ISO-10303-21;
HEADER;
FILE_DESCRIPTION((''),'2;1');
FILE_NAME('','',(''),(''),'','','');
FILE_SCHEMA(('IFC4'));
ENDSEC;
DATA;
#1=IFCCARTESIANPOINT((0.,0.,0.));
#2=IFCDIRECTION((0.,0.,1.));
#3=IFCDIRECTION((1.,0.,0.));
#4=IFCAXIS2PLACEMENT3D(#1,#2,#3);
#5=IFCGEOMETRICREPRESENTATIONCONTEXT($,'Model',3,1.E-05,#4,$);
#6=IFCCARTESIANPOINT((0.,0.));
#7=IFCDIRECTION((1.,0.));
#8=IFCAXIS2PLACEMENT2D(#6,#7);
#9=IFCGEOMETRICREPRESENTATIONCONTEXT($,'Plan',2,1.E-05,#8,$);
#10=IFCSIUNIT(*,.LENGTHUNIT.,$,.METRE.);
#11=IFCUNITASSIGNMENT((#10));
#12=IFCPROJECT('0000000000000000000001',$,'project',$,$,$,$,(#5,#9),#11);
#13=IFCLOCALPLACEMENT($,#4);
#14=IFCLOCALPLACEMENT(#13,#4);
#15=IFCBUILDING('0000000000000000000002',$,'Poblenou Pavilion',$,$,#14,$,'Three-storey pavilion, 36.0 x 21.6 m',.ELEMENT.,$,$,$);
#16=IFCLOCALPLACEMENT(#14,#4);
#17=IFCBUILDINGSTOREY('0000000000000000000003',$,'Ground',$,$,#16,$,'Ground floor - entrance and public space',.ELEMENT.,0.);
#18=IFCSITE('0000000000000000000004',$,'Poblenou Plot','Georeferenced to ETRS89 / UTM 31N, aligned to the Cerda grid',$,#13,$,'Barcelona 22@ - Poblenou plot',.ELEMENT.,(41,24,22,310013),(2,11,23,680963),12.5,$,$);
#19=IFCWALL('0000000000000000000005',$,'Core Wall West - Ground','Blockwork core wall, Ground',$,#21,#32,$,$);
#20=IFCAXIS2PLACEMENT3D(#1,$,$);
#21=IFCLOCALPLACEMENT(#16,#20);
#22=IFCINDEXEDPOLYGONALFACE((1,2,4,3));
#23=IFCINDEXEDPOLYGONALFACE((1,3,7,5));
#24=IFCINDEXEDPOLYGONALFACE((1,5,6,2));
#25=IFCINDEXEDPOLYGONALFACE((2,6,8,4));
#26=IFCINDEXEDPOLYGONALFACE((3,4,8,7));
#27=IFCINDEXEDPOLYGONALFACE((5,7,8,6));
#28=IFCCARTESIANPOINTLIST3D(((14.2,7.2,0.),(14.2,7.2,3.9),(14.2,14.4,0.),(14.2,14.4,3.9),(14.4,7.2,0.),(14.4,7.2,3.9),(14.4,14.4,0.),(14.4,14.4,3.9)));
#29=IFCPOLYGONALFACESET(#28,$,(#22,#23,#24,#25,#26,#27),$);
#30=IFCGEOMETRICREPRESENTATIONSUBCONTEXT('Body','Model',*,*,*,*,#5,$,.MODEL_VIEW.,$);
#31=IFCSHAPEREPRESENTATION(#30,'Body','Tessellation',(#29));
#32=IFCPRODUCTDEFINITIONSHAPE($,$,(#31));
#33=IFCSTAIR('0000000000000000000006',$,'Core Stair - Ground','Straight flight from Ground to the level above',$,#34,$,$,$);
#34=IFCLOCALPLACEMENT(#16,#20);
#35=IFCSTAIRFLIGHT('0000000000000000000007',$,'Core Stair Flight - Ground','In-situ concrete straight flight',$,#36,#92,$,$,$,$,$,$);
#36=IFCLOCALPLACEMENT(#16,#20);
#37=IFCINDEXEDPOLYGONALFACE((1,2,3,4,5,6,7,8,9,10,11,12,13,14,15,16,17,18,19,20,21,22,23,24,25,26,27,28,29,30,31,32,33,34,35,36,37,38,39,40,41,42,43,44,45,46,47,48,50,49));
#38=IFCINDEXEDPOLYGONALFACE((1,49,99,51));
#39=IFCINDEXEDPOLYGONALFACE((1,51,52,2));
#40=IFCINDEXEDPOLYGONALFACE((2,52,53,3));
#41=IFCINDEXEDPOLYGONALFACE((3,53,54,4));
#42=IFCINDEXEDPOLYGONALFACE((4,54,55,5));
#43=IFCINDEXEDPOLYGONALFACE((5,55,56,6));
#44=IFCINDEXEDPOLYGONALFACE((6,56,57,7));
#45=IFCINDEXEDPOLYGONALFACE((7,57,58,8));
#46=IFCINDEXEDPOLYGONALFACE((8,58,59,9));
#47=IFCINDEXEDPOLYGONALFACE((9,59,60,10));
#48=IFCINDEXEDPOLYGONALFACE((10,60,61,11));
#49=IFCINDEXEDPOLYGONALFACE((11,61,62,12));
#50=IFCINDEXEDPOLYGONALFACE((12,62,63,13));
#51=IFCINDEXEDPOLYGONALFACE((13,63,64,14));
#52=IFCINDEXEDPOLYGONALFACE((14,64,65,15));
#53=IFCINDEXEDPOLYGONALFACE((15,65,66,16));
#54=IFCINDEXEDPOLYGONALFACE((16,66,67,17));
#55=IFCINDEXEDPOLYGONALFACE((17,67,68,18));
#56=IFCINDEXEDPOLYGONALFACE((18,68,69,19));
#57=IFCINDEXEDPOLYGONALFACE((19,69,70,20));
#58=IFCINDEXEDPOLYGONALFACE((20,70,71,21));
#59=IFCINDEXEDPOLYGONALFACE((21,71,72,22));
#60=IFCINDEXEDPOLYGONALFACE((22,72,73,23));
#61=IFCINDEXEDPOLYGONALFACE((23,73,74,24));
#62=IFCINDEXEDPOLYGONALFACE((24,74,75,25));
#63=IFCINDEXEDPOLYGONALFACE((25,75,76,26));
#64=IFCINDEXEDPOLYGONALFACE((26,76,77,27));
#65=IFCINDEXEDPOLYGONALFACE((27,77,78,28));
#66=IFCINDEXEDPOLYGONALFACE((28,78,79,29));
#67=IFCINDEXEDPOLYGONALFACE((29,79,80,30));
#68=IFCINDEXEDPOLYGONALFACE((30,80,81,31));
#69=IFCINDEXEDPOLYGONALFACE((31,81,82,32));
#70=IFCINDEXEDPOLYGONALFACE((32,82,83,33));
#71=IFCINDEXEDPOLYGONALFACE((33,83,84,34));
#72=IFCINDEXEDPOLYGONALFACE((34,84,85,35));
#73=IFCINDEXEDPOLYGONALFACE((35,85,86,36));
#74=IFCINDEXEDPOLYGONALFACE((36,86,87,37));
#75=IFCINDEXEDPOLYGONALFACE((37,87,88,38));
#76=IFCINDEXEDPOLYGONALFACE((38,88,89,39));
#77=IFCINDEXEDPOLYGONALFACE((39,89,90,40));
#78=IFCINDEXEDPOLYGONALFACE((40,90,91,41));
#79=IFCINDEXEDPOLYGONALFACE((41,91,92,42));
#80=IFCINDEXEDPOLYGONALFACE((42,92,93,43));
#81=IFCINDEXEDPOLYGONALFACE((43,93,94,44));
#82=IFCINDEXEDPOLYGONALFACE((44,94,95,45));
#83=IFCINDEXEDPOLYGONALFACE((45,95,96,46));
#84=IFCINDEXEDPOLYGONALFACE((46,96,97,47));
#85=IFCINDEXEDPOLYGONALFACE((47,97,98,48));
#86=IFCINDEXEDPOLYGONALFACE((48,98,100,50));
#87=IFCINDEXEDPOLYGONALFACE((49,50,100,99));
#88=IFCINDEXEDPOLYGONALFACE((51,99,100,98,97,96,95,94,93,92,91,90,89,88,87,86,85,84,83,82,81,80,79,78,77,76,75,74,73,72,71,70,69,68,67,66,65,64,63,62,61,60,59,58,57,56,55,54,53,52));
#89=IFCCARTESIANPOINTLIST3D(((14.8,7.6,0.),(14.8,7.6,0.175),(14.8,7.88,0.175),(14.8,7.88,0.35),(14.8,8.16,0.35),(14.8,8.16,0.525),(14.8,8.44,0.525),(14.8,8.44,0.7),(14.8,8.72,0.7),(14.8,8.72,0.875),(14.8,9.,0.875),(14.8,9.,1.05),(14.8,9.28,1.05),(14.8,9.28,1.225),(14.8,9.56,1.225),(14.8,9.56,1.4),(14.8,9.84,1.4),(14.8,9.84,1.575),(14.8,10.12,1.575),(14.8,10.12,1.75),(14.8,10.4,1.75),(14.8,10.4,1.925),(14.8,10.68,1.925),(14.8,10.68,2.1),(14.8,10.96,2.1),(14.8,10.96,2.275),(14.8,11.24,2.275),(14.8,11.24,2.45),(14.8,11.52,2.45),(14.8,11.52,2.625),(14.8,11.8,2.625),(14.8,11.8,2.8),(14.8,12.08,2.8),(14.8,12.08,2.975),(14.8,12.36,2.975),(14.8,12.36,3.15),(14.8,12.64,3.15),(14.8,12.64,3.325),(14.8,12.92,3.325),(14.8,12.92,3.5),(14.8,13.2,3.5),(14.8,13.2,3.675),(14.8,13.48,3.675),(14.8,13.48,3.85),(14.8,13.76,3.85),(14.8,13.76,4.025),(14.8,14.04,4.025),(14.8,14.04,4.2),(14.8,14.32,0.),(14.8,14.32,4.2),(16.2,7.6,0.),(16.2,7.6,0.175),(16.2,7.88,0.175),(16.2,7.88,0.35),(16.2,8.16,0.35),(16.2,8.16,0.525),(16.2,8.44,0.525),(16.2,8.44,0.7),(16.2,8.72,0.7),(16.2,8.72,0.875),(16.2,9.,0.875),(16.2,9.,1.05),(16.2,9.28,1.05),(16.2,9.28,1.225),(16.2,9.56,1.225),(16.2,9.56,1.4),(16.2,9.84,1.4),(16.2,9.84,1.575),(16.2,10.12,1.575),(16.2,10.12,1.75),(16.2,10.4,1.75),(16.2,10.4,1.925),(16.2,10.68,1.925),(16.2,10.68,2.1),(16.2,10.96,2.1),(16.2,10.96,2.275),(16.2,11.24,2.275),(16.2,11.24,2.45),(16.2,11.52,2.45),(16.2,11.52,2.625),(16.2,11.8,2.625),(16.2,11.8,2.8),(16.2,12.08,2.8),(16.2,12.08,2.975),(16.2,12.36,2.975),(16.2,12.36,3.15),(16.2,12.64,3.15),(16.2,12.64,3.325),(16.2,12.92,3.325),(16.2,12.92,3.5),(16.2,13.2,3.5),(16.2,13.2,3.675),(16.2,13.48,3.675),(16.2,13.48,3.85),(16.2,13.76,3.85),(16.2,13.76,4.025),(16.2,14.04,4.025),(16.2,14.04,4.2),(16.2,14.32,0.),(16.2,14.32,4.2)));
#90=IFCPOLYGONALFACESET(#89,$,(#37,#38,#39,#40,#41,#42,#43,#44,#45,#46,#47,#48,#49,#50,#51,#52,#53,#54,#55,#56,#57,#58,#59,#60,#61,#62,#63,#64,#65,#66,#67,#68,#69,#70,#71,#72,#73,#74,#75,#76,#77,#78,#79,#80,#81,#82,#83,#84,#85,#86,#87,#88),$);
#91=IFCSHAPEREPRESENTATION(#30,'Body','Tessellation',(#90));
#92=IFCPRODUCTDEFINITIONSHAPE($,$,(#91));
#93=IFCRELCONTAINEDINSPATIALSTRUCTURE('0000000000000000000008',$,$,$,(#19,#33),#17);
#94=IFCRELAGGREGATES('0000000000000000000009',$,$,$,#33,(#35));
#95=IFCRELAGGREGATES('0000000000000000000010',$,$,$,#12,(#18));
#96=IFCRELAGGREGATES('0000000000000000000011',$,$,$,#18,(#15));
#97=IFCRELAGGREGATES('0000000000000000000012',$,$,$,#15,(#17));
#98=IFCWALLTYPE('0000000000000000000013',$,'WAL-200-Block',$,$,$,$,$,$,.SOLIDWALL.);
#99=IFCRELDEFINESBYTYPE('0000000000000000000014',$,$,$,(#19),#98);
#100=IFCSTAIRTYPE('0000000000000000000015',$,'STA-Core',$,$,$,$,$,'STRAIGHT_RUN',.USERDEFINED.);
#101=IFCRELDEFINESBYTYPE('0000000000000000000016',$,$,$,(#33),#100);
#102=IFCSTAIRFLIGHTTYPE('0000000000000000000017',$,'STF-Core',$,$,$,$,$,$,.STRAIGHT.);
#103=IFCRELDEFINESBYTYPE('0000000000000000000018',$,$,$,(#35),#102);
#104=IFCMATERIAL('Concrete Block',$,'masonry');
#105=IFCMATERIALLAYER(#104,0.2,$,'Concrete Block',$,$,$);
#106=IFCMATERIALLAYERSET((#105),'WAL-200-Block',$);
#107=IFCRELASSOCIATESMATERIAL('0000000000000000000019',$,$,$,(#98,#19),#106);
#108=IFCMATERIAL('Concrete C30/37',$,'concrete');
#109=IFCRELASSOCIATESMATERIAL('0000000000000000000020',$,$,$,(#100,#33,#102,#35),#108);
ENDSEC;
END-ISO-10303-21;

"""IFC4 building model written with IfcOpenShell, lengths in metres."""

from ifc_helpers import new_model, si_unit, frame, origin_with_axes, origin_2d_with_axis, place, context, subcontext, project, spatial, line, indexed_curve, outline, extrude, material, layer, layer_set, layer_usage, type_object, element, aggregate, save


model = new_model("IFC4")

# Units and contexts
model_context = context("Model", 3, precision=1e-05, world=origin_with_axes())
plan_context = context("Plan", 2, precision=1e-05, world=origin_2d_with_axis())
body_context = subcontext(model_context, "Body", "Model", "MODEL_VIEW")
ifc_project = project(units=[si_unit("LENGTHUNIT", "METRE")], contexts=[model_context, plan_context])

# Site, building, storey
site_placement = place(None, origin_with_axes())
site = spatial("IfcSite", under=ifc_project, at=site_placement, Name="Poblenou Plot", Description="Georeferenced to ETRS89 / UTM 31N, aligned to the Cerda grid", LongName="Barcelona 22@ - Poblenou plot", CompositionType="ELEMENT", RefLatitude=(41, 24, 22, 310013), RefLongitude=(2, 11, 23, 680963), RefElevation=12.5)
building_placement = place(site_placement, origin_with_axes())
building = spatial("IfcBuilding", under=site, at=building_placement, Name="Poblenou Pavilion", LongName="Three-storey pavilion, 36.0 x 21.6 m", CompositionType="ELEMENT")
storey_placement = place(building_placement, origin_with_axes())
storey = spatial("IfcBuildingStorey", under=building, at=storey_placement, Name="Ground", LongName="Ground floor - entrance and public space", CompositionType="ELEMENT", Elevation=0.0)

# Wall
ifc_material_1 = material(Name="Concrete Block", Category="masonry")
ifc_layer_1 = layer(ifc_material_1, 0.2, Name="Concrete Block")
ifc_layer_set_1 = layer_set([ifc_layer_1], Name="WAL-200-Block")
wall_type = type_object("IfcWallType", Name="WAL-200-Block", PredefinedType="SOLIDWALL", material=ifc_layer_set_1)
ifc_layer_usage_1 = layer_usage(ifc_layer_set_1, "AXIS2", "POSITIVE", 0.0)
wall_1_placement = place(storey_placement, frame((14.4, 7.2, 0.0), z_axis=(0.0, 0.0, 1.0), x_axis=(0.0, 1.0, 0.0)))
element("IfcWall", 1, at=wall_1_placement, inside=storey, type_object=wall_type, material=ifc_layer_usage_1, Name="Core Wall West - Ground", Description="Blockwork core wall, Ground", context=body_context, shape_type="SweptSolid", body=[
    extrude(outline(indexed_curve([(0.0, 0.0), (7.2, 0.0), (7.2, 0.2), (0.0, 0.2)], segments=[line(1, 2, 3, 4, 1)])), origin_with_axes(), (0.0, 0.0, 1.0), 3.9),
])

# Stair, stair flight
ifc_material_2 = material(Name="Concrete C30/37", Category="concrete")
stair_type = type_object("IfcStairType", Name="STA-Core", ElementType="STRAIGHT_RUN", PredefinedType="USERDEFINED", material=ifc_material_2)
stair_placement = place(storey_placement, frame((14.8, 7.6, 0.0), z_axis=(0.0, 0.0, 1.0), x_axis=(1.0, 0.0, 0.0)))
stair = element("IfcStair", 2, at=stair_placement, inside=storey, type_object=stair_type, material=ifc_material_2, Name="Core Stair - Ground", Description="Straight flight from Ground to the level above")
stair_flight_type = type_object("IfcStairFlightType", Name="STF-Core", PredefinedType="STRAIGHT", material=ifc_material_2)
stair_flight_placement = place(stair_placement, frame((0.0, 0.0, 0.0), z_axis=(1.0, 0.0, 0.0), x_axis=(0.0, 1.0, 0.0)))
stair_flight = element("IfcStairFlight", 3, at=stair_flight_placement, type_object=stair_flight_type, material=ifc_material_2, Name="Core Stair Flight - Ground", Description="In-situ concrete straight flight", context=body_context, shape_type="SweptSolid", body=[
    extrude(outline(indexed_curve([(0.0, 0.0), (6.72, 0.0), (6.72, 4.2), (6.44, 4.2), (6.44, 4.025), (6.16, 4.025), (6.16, 3.85), (5.88, 3.85), (5.88, 3.675), (5.6, 3.675), (5.6, 3.5), (5.32, 3.5), (5.32, 3.325), (5.04, 3.325), (5.04, 3.15), (4.76, 3.15), (4.76, 2.975), (4.48, 2.975), (4.48, 2.8), (4.2, 2.8), (4.2, 2.625), (3.92, 2.625), (3.92, 2.45), (3.64, 2.45), (3.64, 2.275), (3.36, 2.275), (3.36, 2.1), (3.08, 2.1), (3.08, 1.925), (2.8, 1.925), (2.8, 1.75), (2.52, 1.75), (2.52, 1.575), (2.24, 1.575), (2.24, 1.4), (1.96, 1.4), (1.96, 1.225), (1.68, 1.225), (1.68, 1.05), (1.4, 1.05), (1.4, 0.875), (1.12, 0.875), (1.12, 0.7), (0.84, 0.7), (0.84, 0.525), (0.56, 0.525), (0.56, 0.35), (0.28, 0.35), (0.28, 0.175), (0.0, 0.175)], segments=[line(1, 2, 3, 4, 5, 6, 7, 8, 9, 10, 11, 12, 13, 14, 15, 16, 17, 18, 19, 20, 21, 22, 23, 24, 25, 26, 27, 28, 29, 30, 31, 32, 33, 34, 35, 36, 37, 38, 39, 40, 41, 42, 43, 44, 45, 46, 47, 48, 49, 50, 1)])), origin_with_axes(), (0.0, 0.0, 1.0), 1.4),
])
aggregate(stair, [stair_flight])

save(model, "model.ifc")
